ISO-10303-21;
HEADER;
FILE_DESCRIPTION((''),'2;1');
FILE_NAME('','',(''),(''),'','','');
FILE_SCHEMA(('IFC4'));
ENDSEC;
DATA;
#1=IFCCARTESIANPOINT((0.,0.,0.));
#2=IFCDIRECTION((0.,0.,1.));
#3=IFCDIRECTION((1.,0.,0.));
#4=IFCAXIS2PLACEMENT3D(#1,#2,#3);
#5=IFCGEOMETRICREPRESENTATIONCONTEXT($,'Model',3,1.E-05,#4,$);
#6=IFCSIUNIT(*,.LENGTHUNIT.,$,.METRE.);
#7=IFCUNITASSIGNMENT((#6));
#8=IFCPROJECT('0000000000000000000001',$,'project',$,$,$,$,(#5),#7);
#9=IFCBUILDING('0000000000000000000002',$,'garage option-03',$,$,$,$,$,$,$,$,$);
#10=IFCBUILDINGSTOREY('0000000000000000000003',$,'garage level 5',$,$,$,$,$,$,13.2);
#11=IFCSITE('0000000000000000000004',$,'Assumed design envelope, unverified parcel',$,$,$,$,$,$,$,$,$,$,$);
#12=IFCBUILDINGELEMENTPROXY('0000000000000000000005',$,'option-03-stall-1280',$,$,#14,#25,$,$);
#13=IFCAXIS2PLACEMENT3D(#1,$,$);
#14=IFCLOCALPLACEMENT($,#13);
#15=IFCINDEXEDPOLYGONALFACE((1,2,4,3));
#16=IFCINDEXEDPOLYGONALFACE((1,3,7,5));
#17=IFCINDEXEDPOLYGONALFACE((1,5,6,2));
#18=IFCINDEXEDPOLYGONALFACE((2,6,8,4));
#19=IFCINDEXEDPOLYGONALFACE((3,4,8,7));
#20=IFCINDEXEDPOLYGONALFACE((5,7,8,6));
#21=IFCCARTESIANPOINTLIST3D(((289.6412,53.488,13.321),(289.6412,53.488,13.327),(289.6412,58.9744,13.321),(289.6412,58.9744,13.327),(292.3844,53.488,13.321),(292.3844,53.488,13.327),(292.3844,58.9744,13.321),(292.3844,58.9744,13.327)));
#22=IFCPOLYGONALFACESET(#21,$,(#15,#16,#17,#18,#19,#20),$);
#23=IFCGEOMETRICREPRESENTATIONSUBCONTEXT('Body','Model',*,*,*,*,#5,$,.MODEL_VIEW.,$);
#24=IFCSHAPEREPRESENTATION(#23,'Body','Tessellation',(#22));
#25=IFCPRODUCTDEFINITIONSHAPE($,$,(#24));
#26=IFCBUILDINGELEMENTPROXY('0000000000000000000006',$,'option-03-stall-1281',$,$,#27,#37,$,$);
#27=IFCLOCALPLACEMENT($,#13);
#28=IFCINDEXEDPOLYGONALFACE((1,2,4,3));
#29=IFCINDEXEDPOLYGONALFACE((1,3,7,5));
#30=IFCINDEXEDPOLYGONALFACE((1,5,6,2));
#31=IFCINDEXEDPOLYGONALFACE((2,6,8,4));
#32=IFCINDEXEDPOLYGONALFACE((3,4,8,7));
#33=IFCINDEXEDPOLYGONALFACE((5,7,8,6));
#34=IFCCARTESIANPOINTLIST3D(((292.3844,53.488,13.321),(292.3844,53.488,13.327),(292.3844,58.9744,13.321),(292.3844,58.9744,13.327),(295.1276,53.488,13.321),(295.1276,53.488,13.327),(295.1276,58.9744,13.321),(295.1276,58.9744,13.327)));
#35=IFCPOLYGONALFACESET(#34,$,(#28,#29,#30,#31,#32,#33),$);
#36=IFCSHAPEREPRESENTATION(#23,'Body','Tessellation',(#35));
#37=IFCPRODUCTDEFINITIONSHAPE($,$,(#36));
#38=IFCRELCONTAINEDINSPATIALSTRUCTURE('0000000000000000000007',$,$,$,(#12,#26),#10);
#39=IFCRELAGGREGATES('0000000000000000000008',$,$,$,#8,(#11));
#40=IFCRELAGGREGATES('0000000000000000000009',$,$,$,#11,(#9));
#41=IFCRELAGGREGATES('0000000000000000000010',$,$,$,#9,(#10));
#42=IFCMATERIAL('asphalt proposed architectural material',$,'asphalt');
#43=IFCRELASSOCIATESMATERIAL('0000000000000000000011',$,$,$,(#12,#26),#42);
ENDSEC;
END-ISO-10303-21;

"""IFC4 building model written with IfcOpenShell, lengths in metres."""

from ifc_helpers import new_model, si_unit, frame, origin_with_axes, place, context, subcontext, project, spatial, rectangle, extrude, material, element, save


model = new_model("IFC4")

# Units and contexts
model_context = context("Model", 3, precision=1e-05, world=origin_with_axes())
body_context = subcontext(model_context, "Body", "Model", "MODEL_VIEW")
ifc_project = project(units=[si_unit("LENGTHUNIT", "METRE")], contexts=[model_context])

# Site, building, storey
site = spatial("IfcSite", under=ifc_project, Name="Assumed design envelope, unverified parcel")
building = spatial("IfcBuilding", under=site, Name="garage option-03")
storey = spatial("IfcBuildingStorey", under=building, Name="garage level 5", Elevation=13.2)

# Building element proxies
ifc_material = material(Name="asphalt proposed architectural material", Category="asphalt")
for number, where, z_axis, x_axis, name in (
    (1, (291.0128, 56.2312, 13.321), (0.0, 0.0, 1.0), (1.0, 0.0, 0.0), "option-03-stall-1280"),
    (2, (293.756, 56.2312, 13.321), (0.0, 0.0, 1.0), (1.0, 0.0, 0.0), "option-03-stall-1281"),
):
    element("IfcBuildingElementProxy", number, at=place(None, frame(where, z_axis=z_axis, x_axis=x_axis)), inside=storey, material=ifc_material, Name=name, context=body_context, shape_type="SweptSolid", body=[
        extrude(rectangle(XDim=2.7432, YDim=5.4864), origin_with_axes(), (0.0, 0.0, 1.0), 0.006),
    ])

save(model, "model.ifc")
